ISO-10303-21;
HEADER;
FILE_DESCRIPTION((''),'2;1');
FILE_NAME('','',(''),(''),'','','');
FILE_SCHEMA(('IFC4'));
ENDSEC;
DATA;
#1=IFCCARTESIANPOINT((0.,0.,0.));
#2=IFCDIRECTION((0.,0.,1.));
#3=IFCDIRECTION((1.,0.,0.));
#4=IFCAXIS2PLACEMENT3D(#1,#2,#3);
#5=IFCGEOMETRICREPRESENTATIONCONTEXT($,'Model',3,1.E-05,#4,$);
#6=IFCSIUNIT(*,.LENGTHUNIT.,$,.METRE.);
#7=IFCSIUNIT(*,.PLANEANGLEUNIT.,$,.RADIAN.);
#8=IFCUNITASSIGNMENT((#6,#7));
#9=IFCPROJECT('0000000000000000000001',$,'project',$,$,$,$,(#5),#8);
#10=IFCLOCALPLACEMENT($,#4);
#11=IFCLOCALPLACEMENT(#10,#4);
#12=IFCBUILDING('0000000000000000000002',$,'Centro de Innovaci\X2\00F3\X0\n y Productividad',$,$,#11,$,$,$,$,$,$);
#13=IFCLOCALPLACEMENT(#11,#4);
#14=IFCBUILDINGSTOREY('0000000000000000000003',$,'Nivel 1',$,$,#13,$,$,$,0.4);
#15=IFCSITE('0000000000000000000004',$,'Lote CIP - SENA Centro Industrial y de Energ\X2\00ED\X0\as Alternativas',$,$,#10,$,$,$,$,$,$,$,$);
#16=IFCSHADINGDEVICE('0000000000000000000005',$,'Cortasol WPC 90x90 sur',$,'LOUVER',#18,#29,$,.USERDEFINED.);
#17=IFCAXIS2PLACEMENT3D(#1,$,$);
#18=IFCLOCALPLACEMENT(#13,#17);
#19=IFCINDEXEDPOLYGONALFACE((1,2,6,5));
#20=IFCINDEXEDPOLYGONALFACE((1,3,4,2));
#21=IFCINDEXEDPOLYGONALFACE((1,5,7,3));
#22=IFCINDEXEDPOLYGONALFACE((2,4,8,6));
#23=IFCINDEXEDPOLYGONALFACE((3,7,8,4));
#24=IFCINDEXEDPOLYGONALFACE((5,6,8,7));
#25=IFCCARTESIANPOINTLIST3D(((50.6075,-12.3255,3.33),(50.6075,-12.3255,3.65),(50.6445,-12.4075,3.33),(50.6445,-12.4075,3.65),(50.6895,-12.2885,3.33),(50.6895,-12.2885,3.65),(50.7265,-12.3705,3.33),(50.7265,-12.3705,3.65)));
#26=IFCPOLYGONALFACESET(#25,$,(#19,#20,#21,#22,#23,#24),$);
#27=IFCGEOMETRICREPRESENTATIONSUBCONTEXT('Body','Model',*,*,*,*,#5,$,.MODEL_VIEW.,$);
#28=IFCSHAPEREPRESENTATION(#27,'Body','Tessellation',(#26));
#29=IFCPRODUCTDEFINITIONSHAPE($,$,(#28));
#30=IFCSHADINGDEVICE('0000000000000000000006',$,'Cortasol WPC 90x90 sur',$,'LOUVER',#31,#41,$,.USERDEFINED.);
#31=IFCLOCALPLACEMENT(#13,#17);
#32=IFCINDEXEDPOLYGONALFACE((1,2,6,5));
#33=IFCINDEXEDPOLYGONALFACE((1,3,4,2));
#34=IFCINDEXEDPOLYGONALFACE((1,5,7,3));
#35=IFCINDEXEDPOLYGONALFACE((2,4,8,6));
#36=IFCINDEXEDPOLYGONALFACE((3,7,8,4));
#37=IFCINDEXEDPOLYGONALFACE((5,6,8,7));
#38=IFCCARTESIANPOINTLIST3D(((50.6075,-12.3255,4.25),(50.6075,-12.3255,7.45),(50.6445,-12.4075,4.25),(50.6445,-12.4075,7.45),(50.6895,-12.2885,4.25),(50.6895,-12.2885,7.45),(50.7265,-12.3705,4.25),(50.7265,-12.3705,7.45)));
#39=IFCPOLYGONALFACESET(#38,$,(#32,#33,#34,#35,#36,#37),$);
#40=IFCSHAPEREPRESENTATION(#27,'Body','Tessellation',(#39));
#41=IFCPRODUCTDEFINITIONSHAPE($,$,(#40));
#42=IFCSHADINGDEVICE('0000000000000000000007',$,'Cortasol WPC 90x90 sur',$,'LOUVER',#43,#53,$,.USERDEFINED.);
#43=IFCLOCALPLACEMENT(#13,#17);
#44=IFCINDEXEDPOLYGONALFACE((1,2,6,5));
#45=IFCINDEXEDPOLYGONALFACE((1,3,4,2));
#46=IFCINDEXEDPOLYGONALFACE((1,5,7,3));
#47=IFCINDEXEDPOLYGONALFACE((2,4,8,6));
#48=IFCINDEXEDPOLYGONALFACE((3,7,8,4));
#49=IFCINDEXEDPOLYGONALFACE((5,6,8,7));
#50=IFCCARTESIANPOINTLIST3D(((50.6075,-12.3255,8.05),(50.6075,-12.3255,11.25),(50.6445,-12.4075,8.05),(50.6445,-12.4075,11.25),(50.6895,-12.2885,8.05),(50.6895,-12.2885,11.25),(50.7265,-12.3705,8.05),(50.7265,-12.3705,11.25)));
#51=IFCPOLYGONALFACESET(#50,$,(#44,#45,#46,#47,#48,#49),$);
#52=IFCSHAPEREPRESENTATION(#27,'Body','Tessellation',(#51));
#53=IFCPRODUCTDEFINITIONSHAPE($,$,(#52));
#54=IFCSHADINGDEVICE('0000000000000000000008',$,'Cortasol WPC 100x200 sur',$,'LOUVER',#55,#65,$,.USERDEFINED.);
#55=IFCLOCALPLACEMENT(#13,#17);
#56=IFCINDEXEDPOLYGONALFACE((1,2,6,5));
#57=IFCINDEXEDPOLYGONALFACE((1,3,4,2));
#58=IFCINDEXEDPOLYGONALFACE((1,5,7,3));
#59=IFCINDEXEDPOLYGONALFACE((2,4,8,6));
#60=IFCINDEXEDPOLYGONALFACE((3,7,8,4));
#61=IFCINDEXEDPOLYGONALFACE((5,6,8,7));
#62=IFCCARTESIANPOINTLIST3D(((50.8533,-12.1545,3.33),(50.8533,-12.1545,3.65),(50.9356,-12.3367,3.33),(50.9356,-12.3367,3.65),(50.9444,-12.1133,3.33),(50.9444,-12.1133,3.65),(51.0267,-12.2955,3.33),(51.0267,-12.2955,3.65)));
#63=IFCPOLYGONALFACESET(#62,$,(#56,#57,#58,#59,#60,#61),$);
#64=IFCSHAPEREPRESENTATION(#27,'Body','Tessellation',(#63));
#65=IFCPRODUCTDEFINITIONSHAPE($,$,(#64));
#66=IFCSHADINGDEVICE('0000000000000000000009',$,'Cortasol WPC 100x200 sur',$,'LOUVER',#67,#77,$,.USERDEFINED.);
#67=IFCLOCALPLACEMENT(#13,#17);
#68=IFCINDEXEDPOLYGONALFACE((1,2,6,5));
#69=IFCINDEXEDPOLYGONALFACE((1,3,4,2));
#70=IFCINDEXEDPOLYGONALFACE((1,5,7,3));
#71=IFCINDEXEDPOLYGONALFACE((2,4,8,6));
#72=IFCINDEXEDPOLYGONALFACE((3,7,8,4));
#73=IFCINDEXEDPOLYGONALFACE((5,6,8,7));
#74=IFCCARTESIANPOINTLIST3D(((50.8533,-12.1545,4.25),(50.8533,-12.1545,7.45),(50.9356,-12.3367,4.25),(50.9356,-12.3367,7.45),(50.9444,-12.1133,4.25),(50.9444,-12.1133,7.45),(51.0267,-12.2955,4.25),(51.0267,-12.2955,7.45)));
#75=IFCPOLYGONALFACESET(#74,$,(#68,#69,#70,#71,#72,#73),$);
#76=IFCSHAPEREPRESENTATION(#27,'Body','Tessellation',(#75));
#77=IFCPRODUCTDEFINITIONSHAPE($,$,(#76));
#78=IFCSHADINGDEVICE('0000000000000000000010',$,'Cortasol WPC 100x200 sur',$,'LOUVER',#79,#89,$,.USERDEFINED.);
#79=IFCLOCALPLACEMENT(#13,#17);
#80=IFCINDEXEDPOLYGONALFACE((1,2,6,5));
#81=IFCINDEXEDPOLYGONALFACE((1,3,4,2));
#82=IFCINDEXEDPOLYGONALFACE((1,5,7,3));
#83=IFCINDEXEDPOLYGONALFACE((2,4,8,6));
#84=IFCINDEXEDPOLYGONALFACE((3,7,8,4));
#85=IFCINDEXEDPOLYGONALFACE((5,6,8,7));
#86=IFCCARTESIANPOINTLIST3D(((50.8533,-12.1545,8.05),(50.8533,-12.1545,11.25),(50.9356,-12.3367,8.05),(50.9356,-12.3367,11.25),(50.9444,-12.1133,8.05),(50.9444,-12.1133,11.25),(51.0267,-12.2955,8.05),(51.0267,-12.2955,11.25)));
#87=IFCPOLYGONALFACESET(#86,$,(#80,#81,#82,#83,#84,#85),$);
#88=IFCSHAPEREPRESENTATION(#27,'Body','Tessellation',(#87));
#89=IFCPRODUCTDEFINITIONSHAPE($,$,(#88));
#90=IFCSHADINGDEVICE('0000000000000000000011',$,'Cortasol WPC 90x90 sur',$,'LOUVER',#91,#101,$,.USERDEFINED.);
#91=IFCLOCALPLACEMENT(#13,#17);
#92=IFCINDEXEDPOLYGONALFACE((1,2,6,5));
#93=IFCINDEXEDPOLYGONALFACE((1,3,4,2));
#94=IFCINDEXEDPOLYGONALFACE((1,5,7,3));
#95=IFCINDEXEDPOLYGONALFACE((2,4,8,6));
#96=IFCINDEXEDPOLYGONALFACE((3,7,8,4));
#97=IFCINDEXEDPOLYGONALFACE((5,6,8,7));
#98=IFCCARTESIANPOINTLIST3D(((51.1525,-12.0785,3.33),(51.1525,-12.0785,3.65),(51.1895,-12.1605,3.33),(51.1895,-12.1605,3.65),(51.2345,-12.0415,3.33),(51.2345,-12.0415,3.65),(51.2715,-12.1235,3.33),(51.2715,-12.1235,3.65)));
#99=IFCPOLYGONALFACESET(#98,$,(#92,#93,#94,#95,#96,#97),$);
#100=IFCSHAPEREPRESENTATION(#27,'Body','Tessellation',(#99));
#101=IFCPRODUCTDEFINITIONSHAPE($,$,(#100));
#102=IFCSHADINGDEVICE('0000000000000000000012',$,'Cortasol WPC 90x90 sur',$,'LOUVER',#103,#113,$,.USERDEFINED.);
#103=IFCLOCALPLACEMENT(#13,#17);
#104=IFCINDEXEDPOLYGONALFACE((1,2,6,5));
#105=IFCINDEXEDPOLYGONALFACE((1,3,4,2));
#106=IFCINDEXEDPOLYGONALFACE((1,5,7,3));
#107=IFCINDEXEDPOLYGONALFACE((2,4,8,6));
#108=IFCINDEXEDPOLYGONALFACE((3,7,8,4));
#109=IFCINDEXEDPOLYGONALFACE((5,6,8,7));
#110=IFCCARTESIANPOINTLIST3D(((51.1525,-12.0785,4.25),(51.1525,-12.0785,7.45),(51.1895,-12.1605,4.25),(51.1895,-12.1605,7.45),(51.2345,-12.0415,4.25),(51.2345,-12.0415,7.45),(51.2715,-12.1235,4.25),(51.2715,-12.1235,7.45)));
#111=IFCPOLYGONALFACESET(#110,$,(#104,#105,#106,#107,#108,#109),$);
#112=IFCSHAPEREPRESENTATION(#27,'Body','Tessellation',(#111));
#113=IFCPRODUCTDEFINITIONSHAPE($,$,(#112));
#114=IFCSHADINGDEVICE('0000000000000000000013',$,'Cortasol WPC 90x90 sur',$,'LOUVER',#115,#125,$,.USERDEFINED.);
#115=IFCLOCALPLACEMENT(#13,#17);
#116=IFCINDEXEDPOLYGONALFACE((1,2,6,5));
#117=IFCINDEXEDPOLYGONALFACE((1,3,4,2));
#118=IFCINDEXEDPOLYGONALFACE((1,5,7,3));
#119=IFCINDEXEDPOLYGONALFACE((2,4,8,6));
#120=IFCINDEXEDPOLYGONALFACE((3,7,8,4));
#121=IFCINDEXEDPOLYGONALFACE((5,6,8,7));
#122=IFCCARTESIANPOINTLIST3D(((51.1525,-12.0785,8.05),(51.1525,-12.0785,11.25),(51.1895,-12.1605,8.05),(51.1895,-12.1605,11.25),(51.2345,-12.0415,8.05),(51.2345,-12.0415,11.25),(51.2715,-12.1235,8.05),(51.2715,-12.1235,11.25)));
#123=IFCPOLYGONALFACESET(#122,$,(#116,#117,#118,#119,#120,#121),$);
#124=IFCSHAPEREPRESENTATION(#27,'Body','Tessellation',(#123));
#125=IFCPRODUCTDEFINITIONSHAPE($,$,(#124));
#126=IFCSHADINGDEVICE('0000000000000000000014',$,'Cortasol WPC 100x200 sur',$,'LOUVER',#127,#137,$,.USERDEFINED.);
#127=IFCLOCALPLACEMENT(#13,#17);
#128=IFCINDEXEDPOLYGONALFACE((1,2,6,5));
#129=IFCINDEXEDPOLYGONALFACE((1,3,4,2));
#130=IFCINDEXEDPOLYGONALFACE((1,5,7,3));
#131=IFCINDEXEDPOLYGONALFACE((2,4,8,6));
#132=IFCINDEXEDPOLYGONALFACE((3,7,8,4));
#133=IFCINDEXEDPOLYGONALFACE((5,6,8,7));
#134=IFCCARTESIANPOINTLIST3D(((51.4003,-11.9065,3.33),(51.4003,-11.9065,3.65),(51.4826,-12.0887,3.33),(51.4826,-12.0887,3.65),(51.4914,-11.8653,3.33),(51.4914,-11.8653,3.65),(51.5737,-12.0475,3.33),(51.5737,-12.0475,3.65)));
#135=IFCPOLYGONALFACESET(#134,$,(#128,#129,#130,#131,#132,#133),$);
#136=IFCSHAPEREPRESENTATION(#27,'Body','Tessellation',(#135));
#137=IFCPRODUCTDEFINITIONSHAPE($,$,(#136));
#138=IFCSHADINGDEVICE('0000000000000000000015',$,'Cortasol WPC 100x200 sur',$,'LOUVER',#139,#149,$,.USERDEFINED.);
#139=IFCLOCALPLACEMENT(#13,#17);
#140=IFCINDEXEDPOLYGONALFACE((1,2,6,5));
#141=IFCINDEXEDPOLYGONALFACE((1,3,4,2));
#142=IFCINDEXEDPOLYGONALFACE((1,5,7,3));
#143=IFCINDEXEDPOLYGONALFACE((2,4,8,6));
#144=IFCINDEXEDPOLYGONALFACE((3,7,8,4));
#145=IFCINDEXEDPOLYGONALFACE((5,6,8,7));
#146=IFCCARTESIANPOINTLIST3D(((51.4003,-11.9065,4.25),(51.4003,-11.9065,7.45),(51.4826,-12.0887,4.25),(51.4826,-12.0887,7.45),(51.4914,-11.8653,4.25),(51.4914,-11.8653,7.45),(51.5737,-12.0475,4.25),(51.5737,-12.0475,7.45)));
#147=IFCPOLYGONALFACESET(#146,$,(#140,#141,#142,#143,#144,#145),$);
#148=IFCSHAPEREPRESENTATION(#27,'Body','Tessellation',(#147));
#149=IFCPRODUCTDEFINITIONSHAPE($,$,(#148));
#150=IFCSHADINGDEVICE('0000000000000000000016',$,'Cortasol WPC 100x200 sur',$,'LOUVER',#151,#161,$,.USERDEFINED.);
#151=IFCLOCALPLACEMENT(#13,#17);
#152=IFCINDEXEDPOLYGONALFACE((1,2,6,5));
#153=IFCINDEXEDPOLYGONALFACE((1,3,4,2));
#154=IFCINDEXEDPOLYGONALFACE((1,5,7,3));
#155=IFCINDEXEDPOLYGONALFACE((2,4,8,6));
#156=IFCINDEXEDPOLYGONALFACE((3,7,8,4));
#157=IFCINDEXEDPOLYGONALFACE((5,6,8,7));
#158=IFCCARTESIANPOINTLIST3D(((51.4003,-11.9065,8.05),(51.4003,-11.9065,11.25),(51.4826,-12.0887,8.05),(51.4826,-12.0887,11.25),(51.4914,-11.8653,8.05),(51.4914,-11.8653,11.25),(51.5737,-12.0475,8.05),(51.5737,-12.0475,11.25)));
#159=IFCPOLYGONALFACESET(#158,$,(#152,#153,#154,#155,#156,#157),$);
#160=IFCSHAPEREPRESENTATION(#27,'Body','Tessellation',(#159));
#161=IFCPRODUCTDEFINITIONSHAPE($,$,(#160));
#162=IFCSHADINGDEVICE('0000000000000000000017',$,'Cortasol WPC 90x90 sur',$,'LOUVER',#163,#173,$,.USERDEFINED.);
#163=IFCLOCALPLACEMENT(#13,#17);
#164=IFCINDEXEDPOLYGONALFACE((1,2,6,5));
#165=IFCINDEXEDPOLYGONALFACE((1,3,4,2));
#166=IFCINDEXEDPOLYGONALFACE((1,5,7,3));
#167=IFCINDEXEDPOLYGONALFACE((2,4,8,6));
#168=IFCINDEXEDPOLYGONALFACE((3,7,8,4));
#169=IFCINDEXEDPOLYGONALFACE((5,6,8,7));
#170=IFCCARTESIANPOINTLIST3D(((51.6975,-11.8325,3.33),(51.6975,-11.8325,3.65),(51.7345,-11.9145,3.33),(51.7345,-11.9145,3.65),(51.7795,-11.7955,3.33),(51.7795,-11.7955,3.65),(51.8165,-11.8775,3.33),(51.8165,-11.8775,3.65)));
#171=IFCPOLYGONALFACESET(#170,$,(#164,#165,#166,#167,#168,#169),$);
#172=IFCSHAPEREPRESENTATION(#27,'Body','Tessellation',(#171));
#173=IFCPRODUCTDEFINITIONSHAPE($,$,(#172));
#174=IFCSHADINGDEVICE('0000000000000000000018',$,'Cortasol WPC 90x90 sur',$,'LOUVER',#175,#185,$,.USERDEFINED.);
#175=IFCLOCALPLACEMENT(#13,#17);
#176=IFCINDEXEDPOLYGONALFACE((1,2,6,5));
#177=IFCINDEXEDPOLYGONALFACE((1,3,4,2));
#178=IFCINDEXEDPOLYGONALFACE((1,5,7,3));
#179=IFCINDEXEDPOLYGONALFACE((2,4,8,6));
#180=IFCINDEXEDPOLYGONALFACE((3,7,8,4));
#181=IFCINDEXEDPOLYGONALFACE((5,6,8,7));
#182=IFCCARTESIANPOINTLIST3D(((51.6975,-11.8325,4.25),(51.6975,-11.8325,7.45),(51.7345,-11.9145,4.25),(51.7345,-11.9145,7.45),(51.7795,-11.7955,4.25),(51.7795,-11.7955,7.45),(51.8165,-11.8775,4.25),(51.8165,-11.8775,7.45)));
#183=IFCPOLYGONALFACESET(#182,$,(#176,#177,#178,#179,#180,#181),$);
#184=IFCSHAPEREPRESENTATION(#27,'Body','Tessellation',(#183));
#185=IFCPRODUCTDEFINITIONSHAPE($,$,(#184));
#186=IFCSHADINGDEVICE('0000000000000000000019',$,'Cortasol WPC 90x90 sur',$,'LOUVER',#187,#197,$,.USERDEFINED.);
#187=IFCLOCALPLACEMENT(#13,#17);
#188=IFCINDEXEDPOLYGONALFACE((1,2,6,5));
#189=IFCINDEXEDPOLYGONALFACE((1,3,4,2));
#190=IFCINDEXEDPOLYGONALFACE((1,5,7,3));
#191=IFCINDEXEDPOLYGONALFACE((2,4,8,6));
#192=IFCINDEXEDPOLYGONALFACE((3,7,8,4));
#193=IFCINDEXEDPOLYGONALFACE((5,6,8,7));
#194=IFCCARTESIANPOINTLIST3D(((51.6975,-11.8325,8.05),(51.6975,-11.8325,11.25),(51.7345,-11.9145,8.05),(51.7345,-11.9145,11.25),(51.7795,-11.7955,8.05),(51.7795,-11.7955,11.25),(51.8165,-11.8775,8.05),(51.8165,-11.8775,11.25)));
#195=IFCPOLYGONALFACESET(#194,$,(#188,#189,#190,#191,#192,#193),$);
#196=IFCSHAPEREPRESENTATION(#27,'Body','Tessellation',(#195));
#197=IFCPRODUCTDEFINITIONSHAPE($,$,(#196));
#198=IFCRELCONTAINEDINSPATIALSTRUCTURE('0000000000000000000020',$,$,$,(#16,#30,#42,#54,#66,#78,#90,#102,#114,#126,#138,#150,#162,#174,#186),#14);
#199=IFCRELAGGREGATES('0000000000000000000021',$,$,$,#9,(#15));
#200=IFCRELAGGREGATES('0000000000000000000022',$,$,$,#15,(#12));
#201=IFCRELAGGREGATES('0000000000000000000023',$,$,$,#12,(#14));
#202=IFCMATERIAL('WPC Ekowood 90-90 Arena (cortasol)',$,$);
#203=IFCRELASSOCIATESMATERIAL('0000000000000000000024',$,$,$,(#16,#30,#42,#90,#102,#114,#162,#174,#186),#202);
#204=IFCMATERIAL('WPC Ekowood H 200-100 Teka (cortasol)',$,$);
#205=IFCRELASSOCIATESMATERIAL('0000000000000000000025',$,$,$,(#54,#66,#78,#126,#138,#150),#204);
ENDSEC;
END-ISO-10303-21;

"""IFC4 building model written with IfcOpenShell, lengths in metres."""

from ifc_helpers import new_model, si_unit, frame, origin_with_axes, place, context, subcontext, project, spatial, polyline, outline, extrude, material, element, save


model = new_model("IFC4")

# Units and contexts
model_context = context("Model", 3, precision=1e-05, world=origin_with_axes())
body_context = subcontext(model_context, "Body", "Model", "MODEL_VIEW")
ifc_project = project(units=[si_unit("LENGTHUNIT", "METRE"), si_unit("PLANEANGLEUNIT", "RADIAN")], contexts=[model_context])

# Site, building, storey
site_placement = place(None, origin_with_axes())
site = spatial("IfcSite", under=ifc_project, at=site_placement, Name="Lote CIP - SENA Centro Industrial y de Energías Alternativas")
building_placement = place(site_placement, origin_with_axes())
building = spatial("IfcBuilding", under=site, at=building_placement, Name="Centro de Innovación y Productividad")
storey_placement = place(building_placement, origin_with_axes())
storey = spatial("IfcBuildingStorey", under=building, at=storey_placement, Name="Nivel 1", Elevation=0.4)

# Shading devices
ifc_material_1 = material(Name="WPC Ekowood 90-90 Arena (cortasol)")
shading_device_1_placement = place(storey_placement, origin_with_axes())
element("IfcShadingDevice", 1, at=shading_device_1_placement, inside=storey, material=ifc_material_1, Name="Cortasol WPC 90x90 sur", ObjectType="LOUVER", PredefinedType="USERDEFINED", context=body_context, shape_type="SweptSolid", body=[
    extrude(outline(polyline([(50.6445, -12.4075), (50.6075, -12.3255), (50.6895, -12.2885), (50.7265, -12.3705), (50.6445, -12.4075)])), frame((0.0, 0.0, 3.33)), (0.0, 0.0, 1.0), 0.32),
])
shading_device_2_placement = place(storey_placement, origin_with_axes())
element("IfcShadingDevice", 2, at=shading_device_2_placement, inside=storey, material=ifc_material_1, Name="Cortasol WPC 90x90 sur", ObjectType="LOUVER", PredefinedType="USERDEFINED", context=body_context, shape_type="SweptSolid", body=[
    extrude(outline(polyline([(50.6445, -12.4075), (50.6075, -12.3255), (50.6895, -12.2885), (50.7265, -12.3705), (50.6445, -12.4075)])), frame((0.0, 0.0, 4.25)), (0.0, 0.0, 1.0), 3.2),
])
shading_device_3_placement = place(storey_placement, origin_with_axes())
element("IfcShadingDevice", 3, at=shading_device_3_placement, inside=storey, material=ifc_material_1, Name="Cortasol WPC 90x90 sur", ObjectType="LOUVER", PredefinedType="USERDEFINED", context=body_context, shape_type="SweptSolid", body=[
    extrude(outline(polyline([(50.6445, -12.4075), (50.6075, -12.3255), (50.6895, -12.2885), (50.7265, -12.3705), (50.6445, -12.4075)])), frame((0.0, 0.0, 8.05)), (0.0, 0.0, 1.0), 3.2),
])
ifc_material_2 = material(Name="WPC Ekowood H 200-100 Teka (cortasol)")
shading_device_4_placement = place(storey_placement, origin_with_axes())
element("IfcShadingDevice", 4, at=shading_device_4_placement, inside=storey, material=ifc_material_2, Name="Cortasol WPC 100x200 sur", ObjectType="LOUVER", PredefinedType="USERDEFINED", context=body_context, shape_type="SweptSolid", body=[
    extrude(outline(polyline([(50.9356, -12.3367), (50.8533, -12.1545), (50.9444, -12.1133), (51.0267, -12.2955), (50.9356, -12.3367)])), frame((0.0, 0.0, 3.33)), (0.0, 0.0, 1.0), 0.32),
])
shading_device_5_placement = place(storey_placement, origin_with_axes())
element("IfcShadingDevice", 5, at=shading_device_5_placement, inside=storey, material=ifc_material_2, Name="Cortasol WPC 100x200 sur", ObjectType="LOUVER", PredefinedType="USERDEFINED", context=body_context, shape_type="SweptSolid", body=[
    extrude(outline(polyline([(50.9356, -12.3367), (50.8533, -12.1545), (50.9444, -12.1133), (51.0267, -12.2955), (50.9356, -12.3367)])), frame((0.0, 0.0, 4.25)), (0.0, 0.0, 1.0), 3.2),
])
shading_device_6_placement = place(storey_placement, origin_with_axes())
element("IfcShadingDevice", 6, at=shading_device_6_placement, inside=storey, material=ifc_material_2, Name="Cortasol WPC 100x200 sur", ObjectType="LOUVER", PredefinedType="USERDEFINED", context=body_context, shape_type="SweptSolid", body=[
    extrude(outline(polyline([(50.9356, -12.3367), (50.8533, -12.1545), (50.9444, -12.1133), (51.0267, -12.2955), (50.9356, -12.3367)])), frame((0.0, 0.0, 8.05)), (0.0, 0.0, 1.0), 3.2),
])
shading_device_7_placement = place(storey_placement, origin_with_axes())
element("IfcShadingDevice", 7, at=shading_device_7_placement, inside=storey, material=ifc_material_1, Name="Cortasol WPC 90x90 sur", ObjectType="LOUVER", PredefinedType="USERDEFINED", context=body_context, shape_type="SweptSolid", body=[
    extrude(outline(polyline([(51.1895, -12.1605), (51.1525, -12.0785), (51.2345, -12.0415), (51.2715, -12.1235), (51.1895, -12.1605)])), frame((0.0, 0.0, 3.33)), (0.0, 0.0, 1.0), 0.32),
])
shading_device_8_placement = place(storey_placement, origin_with_axes())
element("IfcShadingDevice", 8, at=shading_device_8_placement, inside=storey, material=ifc_material_1, Name="Cortasol WPC 90x90 sur", ObjectType="LOUVER", PredefinedType="USERDEFINED", context=body_context, shape_type="SweptSolid", body=[
    extrude(outline(polyline([(51.1895, -12.1605), (51.1525, -12.0785), (51.2345, -12.0415), (51.2715, -12.1235), (51.1895, -12.1605)])), frame((0.0, 0.0, 4.25)), (0.0, 0.0, 1.0), 3.2),
])
shading_device_9_placement = place(storey_placement, origin_with_axes())
element("IfcShadingDevice", 9, at=shading_device_9_placement, inside=storey, material=ifc_material_1, Name="Cortasol WPC 90x90 sur", ObjectType="LOUVER", PredefinedType="USERDEFINED", context=body_context, shape_type="SweptSolid", body=[
    extrude(outline(polyline([(51.1895, -12.1605), (51.1525, -12.0785), (51.2345, -12.0415), (51.2715, -12.1235), (51.1895, -12.1605)])), frame((0.0, 0.0, 8.05)), (0.0, 0.0, 1.0), 3.2),
])
shading_device_10_placement = place(storey_placement, origin_with_axes())
element("IfcShadingDevice", 10, at=shading_device_10_placement, inside=storey, material=ifc_material_2, Name="Cortasol WPC 100x200 sur", ObjectType="LOUVER", PredefinedType="USERDEFINED", context=body_context, shape_type="SweptSolid", body=[
    extrude(outline(polyline([(51.4826, -12.0887), (51.4003, -11.9065), (51.4914, -11.8653), (51.5737, -12.0475), (51.4826, -12.0887)])), frame((0.0, 0.0, 3.33)), (0.0, 0.0, 1.0), 0.32),
])
shading_device_11_placement = place(storey_placement, origin_with_axes())
element("IfcShadingDevice", 11, at=shading_device_11_placement, inside=storey, material=ifc_material_2, Name="Cortasol WPC 100x200 sur", ObjectType="LOUVER", PredefinedType="USERDEFINED", context=body_context, shape_type="SweptSolid", body=[
    extrude(outline(polyline([(51.4826, -12.0887), (51.4003, -11.9065), (51.4914, -11.8653), (51.5737, -12.0475), (51.4826, -12.0887)])), frame((0.0, 0.0, 4.25)), (0.0, 0.0, 1.0), 3.2),
])
shading_device_12_placement = place(storey_placement, origin_with_axes())
element("IfcShadingDevice", 12, at=shading_device_12_placement, inside=storey, material=ifc_material_2, Name="Cortasol WPC 100x200 sur", ObjectType="LOUVER", PredefinedType="USERDEFINED", context=body_context, shape_type="SweptSolid", body=[
    extrude(outline(polyline([(51.4826, -12.0887), (51.4003, -11.9065), (51.4914, -11.8653), (51.5737, -12.0475), (51.4826, -12.0887)])), frame((0.0, 0.0, 8.05)), (0.0, 0.0, 1.0), 3.2),
])
shading_device_13_placement = place(storey_placement, origin_with_axes())
element("IfcShadingDevice", 13, at=shading_device_13_placement, inside=storey, material=ifc_material_1, Name="Cortasol WPC 90x90 sur", ObjectType="LOUVER", PredefinedType="USERDEFINED", context=body_context, shape_type="SweptSolid", body=[
    extrude(outline(polyline([(51.7345, -11.9145), (51.6975, -11.8325), (51.7795, -11.7955), (51.8165, -11.8775), (51.7345, -11.9145)])), frame((0.0, 0.0, 3.33)), (0.0, 0.0, 1.0), 0.32),
])
shading_device_14_placement = place(storey_placement, origin_with_axes())
element("IfcShadingDevice", 14, at=shading_device_14_placement, inside=storey, material=ifc_material_1, Name="Cortasol WPC 90x90 sur", ObjectType="LOUVER", PredefinedType="USERDEFINED", context=body_context, shape_type="SweptSolid", body=[
    extrude(outline(polyline([(51.7345, -11.9145), (51.6975, -11.8325), (51.7795, -11.7955), (51.8165, -11.8775), (51.7345, -11.9145)])), frame((0.0, 0.0, 4.25)), (0.0, 0.0, 1.0), 3.2),
])
shading_device_15_placement = place(storey_placement, origin_with_axes())
element("IfcShadingDevice", 15, at=shading_device_15_placement, inside=storey, material=ifc_material_1, Name="Cortasol WPC 90x90 sur", ObjectType="LOUVER", PredefinedType="USERDEFINED", context=body_context, shape_type="SweptSolid", body=[
    extrude(outline(polyline([(51.7345, -11.9145), (51.6975, -11.8325), (51.7795, -11.7955), (51.8165, -11.8775), (51.7345, -11.9145)])), frame((0.0, 0.0, 8.05)), (0.0, 0.0, 1.0), 3.2),
])

save(model, "model.ifc")
